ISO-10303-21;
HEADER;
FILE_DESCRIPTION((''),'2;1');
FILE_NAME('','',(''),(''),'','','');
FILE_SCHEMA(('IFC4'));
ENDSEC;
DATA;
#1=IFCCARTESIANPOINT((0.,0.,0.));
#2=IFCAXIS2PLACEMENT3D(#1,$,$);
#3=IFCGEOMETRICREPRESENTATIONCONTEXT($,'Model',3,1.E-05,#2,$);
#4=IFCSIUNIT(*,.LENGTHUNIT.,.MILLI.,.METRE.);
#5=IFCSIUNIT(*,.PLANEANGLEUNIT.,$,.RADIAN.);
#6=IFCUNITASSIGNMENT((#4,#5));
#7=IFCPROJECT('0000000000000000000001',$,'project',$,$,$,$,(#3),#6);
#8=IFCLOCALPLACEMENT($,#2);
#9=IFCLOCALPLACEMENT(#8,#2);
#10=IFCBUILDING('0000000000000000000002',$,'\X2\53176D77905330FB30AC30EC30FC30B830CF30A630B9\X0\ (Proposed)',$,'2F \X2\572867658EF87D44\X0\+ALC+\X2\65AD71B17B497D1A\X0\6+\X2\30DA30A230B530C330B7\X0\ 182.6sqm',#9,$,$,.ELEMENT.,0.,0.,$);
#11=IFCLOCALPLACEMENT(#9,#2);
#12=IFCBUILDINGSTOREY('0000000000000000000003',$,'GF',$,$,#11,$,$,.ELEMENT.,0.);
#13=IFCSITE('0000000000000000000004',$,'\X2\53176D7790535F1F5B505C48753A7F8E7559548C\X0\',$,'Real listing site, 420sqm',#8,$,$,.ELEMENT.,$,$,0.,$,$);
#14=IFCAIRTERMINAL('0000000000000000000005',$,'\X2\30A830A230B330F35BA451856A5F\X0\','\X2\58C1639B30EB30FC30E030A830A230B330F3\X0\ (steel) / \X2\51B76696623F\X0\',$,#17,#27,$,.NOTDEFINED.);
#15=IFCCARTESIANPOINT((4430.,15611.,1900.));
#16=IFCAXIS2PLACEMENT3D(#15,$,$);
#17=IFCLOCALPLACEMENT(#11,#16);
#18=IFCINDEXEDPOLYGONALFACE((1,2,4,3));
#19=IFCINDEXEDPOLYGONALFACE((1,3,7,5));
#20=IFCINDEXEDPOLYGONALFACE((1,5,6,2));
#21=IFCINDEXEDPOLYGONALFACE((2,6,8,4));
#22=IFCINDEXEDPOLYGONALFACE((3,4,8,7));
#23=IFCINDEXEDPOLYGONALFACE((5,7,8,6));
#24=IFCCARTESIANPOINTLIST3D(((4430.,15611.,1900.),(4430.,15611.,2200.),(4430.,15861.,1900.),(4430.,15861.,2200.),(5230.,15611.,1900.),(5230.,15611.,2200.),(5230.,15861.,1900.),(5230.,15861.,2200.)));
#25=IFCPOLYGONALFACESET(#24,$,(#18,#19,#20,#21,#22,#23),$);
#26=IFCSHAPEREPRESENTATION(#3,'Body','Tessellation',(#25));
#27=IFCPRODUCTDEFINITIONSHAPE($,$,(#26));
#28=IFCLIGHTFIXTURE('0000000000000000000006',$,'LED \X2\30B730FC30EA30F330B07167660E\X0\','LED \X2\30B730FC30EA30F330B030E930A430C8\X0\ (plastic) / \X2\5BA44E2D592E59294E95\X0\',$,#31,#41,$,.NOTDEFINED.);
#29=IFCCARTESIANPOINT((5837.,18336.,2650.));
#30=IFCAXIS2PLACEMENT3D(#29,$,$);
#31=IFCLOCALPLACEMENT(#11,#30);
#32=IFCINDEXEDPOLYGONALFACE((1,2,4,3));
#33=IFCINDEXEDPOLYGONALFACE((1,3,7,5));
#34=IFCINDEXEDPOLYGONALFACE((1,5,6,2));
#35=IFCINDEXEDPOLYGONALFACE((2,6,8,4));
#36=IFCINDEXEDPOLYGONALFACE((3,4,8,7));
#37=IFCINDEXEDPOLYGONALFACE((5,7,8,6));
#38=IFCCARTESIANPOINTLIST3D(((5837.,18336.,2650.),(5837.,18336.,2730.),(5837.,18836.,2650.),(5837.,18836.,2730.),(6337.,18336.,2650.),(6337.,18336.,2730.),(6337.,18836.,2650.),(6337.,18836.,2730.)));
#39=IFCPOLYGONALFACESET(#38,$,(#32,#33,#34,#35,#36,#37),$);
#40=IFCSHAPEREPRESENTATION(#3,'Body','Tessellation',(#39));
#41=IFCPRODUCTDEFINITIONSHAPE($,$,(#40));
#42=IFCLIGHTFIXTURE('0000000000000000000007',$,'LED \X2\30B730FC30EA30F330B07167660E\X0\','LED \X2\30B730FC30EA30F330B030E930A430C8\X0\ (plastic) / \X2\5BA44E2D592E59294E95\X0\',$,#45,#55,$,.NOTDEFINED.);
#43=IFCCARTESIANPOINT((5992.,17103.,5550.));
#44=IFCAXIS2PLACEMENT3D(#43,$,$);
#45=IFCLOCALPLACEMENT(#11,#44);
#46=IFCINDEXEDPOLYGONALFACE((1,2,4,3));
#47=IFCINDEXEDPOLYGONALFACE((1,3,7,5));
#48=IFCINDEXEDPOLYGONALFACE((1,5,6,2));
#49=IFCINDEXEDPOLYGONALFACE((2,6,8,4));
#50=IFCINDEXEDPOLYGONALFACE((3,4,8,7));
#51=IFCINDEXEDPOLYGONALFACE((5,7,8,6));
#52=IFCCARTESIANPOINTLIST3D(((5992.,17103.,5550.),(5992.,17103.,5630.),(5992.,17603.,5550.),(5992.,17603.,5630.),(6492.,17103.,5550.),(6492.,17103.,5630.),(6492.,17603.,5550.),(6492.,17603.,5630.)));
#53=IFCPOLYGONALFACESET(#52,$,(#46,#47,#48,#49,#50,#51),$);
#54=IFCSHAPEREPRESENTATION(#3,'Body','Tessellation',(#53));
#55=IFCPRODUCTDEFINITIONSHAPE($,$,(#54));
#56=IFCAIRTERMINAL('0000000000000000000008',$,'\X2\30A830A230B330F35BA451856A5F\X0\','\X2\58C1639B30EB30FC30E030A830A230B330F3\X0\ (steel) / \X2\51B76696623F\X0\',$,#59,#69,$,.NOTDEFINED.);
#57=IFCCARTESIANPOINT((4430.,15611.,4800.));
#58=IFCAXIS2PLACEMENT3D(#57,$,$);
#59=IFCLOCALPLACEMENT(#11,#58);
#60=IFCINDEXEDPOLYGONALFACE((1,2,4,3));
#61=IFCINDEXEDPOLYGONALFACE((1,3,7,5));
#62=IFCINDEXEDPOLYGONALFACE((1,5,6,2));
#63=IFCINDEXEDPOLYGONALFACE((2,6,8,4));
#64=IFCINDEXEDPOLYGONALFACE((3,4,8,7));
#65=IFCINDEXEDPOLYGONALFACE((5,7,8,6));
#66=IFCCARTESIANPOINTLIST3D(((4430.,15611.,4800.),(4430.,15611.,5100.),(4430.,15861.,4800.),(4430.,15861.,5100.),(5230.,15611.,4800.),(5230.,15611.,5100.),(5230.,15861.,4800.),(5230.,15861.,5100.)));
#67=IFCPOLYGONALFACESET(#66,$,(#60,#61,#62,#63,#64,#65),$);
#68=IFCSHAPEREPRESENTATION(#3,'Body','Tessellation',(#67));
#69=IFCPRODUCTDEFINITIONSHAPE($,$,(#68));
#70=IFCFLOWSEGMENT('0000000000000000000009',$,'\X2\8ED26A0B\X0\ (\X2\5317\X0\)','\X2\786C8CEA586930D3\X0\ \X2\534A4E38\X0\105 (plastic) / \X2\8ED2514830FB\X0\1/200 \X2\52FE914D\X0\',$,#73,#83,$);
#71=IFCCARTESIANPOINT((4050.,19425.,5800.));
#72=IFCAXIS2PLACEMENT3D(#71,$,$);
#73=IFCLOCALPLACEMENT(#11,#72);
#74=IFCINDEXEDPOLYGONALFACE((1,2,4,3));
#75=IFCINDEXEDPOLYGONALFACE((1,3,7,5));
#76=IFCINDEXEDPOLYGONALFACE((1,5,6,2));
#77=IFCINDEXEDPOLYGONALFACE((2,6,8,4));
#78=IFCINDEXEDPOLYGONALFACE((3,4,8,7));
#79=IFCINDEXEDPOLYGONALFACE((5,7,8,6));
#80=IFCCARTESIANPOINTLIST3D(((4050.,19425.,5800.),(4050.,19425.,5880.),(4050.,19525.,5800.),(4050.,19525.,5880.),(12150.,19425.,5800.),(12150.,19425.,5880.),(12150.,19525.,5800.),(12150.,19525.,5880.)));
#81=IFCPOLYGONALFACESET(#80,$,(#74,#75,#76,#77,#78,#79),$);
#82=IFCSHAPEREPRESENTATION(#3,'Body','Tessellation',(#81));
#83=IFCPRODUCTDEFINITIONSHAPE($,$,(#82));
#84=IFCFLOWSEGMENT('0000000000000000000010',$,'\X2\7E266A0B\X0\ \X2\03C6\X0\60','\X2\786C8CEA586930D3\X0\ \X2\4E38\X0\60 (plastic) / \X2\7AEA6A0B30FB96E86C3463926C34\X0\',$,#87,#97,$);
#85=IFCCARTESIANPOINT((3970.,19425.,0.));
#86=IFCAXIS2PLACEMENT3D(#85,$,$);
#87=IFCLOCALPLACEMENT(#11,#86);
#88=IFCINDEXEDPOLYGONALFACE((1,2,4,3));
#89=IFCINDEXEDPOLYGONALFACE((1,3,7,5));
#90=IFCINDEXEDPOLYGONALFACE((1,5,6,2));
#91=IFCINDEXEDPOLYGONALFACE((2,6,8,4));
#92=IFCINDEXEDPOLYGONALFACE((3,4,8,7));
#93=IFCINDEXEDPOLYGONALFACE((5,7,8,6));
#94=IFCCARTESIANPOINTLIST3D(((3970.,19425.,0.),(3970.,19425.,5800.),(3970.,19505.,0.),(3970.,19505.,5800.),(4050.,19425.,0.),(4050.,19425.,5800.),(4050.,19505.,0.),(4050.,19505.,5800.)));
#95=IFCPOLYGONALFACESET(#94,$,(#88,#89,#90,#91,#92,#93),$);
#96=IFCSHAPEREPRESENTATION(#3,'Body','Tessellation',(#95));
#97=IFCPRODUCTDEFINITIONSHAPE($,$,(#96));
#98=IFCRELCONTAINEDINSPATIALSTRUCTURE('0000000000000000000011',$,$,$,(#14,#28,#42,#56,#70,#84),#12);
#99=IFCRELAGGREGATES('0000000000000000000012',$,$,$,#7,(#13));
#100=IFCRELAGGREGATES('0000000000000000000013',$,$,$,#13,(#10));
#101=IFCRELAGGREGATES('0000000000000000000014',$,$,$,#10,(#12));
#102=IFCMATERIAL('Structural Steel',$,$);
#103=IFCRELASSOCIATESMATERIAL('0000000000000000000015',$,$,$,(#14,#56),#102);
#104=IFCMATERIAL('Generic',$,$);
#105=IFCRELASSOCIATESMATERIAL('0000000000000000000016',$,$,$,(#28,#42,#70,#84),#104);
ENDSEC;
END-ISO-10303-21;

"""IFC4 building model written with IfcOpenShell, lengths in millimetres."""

from ifc_helpers import new_model, si_unit, frame, frame_2d, origin, place, context, project, spatial, rectangle, extrude, material, element, save


model = new_model("IFC4")

# Units and contexts
model_context = context("Model", 3, precision=1e-05, world=origin())
ifc_project = project(units=[si_unit("LENGTHUNIT", "METRE", prefix="MILLI"), si_unit("PLANEANGLEUNIT", "RADIAN")], contexts=[model_context])

# Site, building, storey
site_placement = place(None, origin())
site = spatial("IfcSite", under=ifc_project, at=site_placement, Name="北海道弟子屈町美留和", ObjectType="Real listing site, 420sqm", CompositionType="ELEMENT", RefElevation=0.0)
building_placement = place(site_placement, origin())
building = spatial("IfcBuilding", under=site, at=building_placement, Name="北海道・ガレージハウス (Proposed)", ObjectType="2F 在来軸組+ALC+断熱等級6+ペアサッシ 182.6sqm", CompositionType="ELEMENT", ElevationOfRefHeight=0.0, ElevationOfTerrain=0.0)
storey_placement = place(building_placement, origin())
storey = spatial("IfcBuildingStorey", under=building, at=storey_placement, Name="GF", CompositionType="ELEMENT", Elevation=0.0)

# Shared definitions
ifc_material_1 = material(Name="Generic")

# Shared definitions
ifc_material_2 = material(Name="Structural Steel")

# Air terminal
air_terminal_1_placement = place(storey_placement, frame((4430.0, 15611.0, 1900.0)))
element("IfcAirTerminal", 1, at=air_terminal_1_placement, inside=storey, material=ifc_material_2, Name="エアコン室内機", Description="壁掛ルームエアコン (steel) / 冷暖房", PredefinedType="NOTDEFINED", context=model_context, shape_type="SweptSolid", body=[
    extrude(rectangle(XDim=800.0, YDim=250.0, at=frame_2d((400.0, 125.0))), frame((4430.0, 15611.0, 1900.0)), (0.0, 0.0, 1.0), 300.0),
])

# Light fixtures
light_fixture_1_placement = place(storey_placement, frame((5837.0, 18336.0, 2650.0)))
element("IfcLightFixture", 2, at=light_fixture_1_placement, inside=storey, material=ifc_material_1, Name="LED シーリング照明", Description="LED シーリングライト (plastic) / 室中央天井", PredefinedType="NOTDEFINED", context=model_context, shape_type="SweptSolid", body=[
    extrude(rectangle(XDim=500.0, YDim=500.0, at=frame_2d((250.0, 250.0))), frame((5837.0, 18336.0, 2650.0)), (0.0, 0.0, 1.0), 80.0),
])
light_fixture_2_placement = place(storey_placement, frame((5992.0, 17103.0, 5550.0)))
element("IfcLightFixture", 3, at=light_fixture_2_placement, inside=storey, material=ifc_material_1, Name="LED シーリング照明", Description="LED シーリングライト (plastic) / 室中央天井", PredefinedType="NOTDEFINED", context=model_context, shape_type="SweptSolid", body=[
    extrude(rectangle(XDim=500.0, YDim=500.0, at=frame_2d((250.0, 250.0))), frame((5992.0, 17103.0, 5550.0)), (0.0, 0.0, 1.0), 80.0),
])

# Air terminal
air_terminal_2_placement = place(storey_placement, frame((4430.0, 15611.0, 4800.0)))
element("IfcAirTerminal", 4, at=air_terminal_2_placement, inside=storey, material=ifc_material_2, Name="エアコン室内機", Description="壁掛ルームエアコン (steel) / 冷暖房", PredefinedType="NOTDEFINED", context=model_context, shape_type="SweptSolid", body=[
    extrude(rectangle(XDim=800.0, YDim=250.0, at=frame_2d((400.0, 125.0))), frame((4430.0, 15611.0, 4800.0)), (0.0, 0.0, 1.0), 300.0),
])

# Flow segments
flow_segment_1_placement = place(storey_placement, frame((4050.0, 19425.0, 5800.0)))
element("IfcFlowSegment", 5, at=flow_segment_1_placement, inside=storey, material=ifc_material_1, Name="軒樋 (北)", Description="硬質塩ビ 半丸105 (plastic) / 軒先・1/200 勾配", context=model_context, shape_type="SweptSolid", body=[
    extrude(rectangle(XDim=8100.0, YDim=100.0, at=frame_2d((4050.0, 50.0))), frame((4050.0, 19425.0, 5800.0)), (0.0, 0.0, 1.0), 80.0),
])
flow_segment_2_placement = place(storey_placement, frame((3970.0, 19425.0, 0.0)))
element("IfcFlowSegment", 6, at=flow_segment_2_placement, inside=storey, material=ifc_material_1, Name="縦樋 φ60", Description="硬質塩ビ 丸60 (plastic) / 竪樋・雨水排水", context=model_context, shape_type="SweptSolid", body=[
    extrude(rectangle(XDim=80.0, YDim=80.0, at=frame_2d((40.0, 40.0))), frame((3970.0, 19425.0, 0.0)), (0.0, 0.0, 1.0), 5800.0),
])

save(model, "model.ifc")
